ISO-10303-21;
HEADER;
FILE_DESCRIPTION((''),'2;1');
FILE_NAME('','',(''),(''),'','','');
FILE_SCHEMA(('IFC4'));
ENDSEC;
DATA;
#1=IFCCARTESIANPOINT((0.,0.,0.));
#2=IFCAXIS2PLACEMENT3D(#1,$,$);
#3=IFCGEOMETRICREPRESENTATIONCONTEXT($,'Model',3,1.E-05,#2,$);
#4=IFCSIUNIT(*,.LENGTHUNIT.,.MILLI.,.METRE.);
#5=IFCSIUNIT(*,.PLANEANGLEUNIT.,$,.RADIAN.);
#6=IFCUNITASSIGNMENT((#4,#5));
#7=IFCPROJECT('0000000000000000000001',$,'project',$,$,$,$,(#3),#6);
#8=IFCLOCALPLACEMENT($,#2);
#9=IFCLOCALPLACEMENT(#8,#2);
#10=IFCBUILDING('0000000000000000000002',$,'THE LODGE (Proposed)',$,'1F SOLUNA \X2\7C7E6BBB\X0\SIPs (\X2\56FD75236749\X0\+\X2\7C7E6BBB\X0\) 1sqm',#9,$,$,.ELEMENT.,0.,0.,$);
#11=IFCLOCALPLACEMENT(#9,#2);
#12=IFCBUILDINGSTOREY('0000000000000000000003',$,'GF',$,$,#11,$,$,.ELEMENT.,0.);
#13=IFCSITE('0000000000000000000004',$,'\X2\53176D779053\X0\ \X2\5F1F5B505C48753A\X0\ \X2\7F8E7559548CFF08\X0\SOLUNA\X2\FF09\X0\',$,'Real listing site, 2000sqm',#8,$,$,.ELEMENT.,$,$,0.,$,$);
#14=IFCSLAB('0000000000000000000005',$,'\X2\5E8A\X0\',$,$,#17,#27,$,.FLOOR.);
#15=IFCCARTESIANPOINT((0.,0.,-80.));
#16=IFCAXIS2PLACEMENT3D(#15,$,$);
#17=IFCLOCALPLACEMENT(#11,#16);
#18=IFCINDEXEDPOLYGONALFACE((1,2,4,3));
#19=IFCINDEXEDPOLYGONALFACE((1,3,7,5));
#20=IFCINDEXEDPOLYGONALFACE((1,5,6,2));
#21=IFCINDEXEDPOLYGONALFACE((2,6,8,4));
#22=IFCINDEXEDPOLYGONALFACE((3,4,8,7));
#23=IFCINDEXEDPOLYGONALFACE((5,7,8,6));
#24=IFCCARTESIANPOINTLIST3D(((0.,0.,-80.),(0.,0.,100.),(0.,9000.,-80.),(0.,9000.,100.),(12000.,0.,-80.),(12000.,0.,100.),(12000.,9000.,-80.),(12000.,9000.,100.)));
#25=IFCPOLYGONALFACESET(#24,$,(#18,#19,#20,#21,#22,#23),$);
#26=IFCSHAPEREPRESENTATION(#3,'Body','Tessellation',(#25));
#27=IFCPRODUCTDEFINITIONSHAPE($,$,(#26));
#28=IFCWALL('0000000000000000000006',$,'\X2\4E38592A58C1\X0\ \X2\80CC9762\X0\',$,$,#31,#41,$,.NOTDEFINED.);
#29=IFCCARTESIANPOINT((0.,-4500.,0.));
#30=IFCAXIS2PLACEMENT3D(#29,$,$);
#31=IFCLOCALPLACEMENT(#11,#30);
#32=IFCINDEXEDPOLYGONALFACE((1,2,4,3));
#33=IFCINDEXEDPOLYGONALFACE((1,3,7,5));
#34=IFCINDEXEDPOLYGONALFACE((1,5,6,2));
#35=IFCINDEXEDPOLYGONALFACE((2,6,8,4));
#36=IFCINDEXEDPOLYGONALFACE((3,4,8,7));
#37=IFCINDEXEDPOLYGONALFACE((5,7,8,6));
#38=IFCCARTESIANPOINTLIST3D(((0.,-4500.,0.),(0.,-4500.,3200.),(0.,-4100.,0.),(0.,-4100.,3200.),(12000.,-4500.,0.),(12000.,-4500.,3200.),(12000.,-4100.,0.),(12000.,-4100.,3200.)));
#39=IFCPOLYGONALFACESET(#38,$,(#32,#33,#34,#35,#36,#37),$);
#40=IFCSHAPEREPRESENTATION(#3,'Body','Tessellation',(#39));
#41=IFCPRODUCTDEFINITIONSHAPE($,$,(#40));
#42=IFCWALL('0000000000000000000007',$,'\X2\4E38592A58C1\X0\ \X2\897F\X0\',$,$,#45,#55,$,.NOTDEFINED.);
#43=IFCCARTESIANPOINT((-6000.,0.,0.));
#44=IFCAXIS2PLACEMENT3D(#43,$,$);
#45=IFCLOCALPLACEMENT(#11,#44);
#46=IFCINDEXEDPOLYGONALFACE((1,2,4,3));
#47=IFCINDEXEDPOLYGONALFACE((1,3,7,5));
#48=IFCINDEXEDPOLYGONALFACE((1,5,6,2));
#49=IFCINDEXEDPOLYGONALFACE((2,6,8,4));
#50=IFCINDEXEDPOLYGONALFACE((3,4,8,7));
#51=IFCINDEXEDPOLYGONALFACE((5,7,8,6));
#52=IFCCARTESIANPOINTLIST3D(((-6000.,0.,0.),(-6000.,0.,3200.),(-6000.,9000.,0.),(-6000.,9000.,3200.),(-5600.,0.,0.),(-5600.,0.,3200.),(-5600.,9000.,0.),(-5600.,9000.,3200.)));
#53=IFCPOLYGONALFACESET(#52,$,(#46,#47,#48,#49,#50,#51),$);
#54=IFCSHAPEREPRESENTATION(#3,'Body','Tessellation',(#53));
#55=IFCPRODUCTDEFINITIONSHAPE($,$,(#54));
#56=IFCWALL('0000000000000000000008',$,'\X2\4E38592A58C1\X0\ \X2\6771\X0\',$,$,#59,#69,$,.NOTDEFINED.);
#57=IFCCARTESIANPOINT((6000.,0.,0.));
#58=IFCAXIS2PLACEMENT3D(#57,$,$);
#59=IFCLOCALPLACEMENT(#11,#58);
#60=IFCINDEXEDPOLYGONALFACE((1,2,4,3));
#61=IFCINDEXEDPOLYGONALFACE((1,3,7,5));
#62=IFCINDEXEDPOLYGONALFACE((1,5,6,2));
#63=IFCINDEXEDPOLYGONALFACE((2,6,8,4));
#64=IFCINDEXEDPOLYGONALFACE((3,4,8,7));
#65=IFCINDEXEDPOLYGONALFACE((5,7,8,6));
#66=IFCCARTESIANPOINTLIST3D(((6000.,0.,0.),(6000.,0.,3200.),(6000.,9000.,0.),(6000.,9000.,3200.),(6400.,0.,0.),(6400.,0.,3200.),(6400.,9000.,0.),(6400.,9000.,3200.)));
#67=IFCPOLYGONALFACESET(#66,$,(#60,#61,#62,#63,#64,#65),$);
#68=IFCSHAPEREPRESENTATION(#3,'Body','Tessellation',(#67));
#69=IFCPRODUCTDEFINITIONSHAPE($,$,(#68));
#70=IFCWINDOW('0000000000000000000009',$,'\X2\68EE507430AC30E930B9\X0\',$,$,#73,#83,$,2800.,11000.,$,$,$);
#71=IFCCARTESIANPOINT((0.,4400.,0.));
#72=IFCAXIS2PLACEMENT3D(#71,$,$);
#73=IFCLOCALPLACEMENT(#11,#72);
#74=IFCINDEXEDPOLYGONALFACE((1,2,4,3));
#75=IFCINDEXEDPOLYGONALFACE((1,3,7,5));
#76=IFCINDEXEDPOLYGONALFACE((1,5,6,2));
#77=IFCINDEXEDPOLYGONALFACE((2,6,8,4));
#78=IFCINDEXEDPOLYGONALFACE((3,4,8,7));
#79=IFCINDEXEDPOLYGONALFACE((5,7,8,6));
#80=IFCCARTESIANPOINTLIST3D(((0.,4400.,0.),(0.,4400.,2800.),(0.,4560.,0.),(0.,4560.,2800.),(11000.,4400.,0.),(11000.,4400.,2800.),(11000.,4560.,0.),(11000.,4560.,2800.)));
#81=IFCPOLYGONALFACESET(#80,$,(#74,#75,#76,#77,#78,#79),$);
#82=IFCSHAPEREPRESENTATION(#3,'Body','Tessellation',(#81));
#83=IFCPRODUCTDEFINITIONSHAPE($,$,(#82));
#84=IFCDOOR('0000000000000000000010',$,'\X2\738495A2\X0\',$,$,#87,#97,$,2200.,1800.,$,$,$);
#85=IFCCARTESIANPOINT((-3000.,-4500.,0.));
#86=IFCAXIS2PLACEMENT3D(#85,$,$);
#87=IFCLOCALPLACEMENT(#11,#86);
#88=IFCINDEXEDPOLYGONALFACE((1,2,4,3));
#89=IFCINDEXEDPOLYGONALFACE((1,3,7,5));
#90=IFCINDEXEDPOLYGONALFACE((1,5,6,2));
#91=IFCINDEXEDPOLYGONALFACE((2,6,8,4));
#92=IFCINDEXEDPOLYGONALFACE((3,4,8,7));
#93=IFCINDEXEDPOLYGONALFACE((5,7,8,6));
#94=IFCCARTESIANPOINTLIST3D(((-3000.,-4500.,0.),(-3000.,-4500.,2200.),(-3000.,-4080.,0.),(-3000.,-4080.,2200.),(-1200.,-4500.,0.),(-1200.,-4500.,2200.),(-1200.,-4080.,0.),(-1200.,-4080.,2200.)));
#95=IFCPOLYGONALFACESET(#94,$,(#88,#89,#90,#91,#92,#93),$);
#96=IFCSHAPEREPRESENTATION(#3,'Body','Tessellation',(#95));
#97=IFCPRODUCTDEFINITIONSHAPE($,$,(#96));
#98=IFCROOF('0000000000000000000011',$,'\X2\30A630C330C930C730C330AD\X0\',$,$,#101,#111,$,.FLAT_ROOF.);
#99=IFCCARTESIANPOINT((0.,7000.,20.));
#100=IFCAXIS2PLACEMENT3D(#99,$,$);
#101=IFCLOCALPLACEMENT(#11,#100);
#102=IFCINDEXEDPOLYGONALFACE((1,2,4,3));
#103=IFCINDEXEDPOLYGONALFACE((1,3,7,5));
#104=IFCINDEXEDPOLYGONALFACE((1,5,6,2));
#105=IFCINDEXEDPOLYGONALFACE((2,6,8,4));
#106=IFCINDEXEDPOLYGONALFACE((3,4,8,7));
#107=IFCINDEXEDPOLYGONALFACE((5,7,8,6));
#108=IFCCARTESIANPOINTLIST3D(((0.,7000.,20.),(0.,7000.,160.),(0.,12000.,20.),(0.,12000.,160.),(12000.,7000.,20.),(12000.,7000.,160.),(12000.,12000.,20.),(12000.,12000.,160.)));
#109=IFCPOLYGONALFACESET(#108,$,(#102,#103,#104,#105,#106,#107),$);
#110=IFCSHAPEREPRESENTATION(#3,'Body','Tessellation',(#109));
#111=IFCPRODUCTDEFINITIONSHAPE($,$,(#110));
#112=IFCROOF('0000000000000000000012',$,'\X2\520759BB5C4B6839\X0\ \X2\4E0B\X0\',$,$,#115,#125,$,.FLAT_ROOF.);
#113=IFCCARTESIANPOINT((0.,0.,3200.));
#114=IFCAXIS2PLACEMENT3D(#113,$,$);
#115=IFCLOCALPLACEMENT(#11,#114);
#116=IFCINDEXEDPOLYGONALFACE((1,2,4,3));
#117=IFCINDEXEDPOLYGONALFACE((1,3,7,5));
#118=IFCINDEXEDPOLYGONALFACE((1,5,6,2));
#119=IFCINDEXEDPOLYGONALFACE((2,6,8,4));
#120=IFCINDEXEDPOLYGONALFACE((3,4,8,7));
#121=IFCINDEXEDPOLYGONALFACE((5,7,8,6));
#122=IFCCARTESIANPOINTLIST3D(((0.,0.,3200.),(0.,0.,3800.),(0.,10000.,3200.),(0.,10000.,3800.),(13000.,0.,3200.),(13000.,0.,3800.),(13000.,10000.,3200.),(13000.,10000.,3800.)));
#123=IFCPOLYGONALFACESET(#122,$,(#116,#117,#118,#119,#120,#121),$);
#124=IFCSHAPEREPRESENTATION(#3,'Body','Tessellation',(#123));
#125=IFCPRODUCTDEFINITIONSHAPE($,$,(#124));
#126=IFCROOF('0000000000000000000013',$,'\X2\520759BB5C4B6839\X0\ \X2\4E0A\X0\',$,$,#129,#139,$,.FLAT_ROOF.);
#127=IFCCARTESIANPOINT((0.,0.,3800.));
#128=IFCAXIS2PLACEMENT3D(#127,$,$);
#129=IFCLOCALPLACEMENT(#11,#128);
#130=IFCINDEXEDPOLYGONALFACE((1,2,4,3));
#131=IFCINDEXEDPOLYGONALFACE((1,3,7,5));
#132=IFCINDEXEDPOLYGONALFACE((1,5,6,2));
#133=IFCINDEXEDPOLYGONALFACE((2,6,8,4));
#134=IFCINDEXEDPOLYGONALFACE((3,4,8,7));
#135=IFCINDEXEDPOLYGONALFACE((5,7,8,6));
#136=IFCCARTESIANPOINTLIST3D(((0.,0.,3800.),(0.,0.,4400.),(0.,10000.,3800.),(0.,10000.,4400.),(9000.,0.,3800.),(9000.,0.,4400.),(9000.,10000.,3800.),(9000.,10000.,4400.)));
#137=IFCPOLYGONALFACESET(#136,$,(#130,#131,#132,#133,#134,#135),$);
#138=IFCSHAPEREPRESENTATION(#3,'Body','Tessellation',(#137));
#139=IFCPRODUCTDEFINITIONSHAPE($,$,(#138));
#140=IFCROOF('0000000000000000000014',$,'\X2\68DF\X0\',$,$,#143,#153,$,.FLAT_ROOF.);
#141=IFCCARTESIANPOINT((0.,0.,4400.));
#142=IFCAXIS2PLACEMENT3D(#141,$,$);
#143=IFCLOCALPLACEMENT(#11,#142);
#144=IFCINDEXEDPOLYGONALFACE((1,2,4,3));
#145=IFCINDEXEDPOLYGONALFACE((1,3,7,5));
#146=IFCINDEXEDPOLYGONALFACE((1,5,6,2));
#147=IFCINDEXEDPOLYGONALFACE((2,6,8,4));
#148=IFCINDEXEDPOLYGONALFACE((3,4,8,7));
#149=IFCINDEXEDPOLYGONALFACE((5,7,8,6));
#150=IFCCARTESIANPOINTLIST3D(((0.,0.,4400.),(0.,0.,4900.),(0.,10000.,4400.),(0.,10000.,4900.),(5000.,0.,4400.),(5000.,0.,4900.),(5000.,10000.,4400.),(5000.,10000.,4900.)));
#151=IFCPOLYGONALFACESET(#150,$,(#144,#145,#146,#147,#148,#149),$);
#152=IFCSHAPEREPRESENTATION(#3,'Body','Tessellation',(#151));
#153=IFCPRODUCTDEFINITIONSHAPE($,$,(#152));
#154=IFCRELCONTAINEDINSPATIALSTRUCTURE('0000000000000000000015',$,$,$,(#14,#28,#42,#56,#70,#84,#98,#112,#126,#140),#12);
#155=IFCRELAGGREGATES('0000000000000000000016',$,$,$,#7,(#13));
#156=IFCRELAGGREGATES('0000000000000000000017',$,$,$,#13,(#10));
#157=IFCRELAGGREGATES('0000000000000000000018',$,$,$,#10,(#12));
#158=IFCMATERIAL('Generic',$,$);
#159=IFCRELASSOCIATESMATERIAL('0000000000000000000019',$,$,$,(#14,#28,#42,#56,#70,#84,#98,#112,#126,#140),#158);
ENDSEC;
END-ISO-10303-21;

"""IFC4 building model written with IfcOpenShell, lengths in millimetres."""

from ifc_helpers import new_model, si_unit, frame, frame_2d, origin, place, context, project, spatial, rectangle, extrude, material, element, fill, save


model = new_model("IFC4")

# Units and contexts
model_context = context("Model", 3, precision=1e-05, world=origin())
ifc_project = project(units=[si_unit("LENGTHUNIT", "METRE", prefix="MILLI"), si_unit("PLANEANGLEUNIT", "RADIAN")], contexts=[model_context])

# Site, building, storey
site_placement = place(None, origin())
site = spatial("IfcSite", under=ifc_project, at=site_placement, Name="北海道 弟子屈町 美留和（SOLUNA）", ObjectType="Real listing site, 2000sqm", CompositionType="ELEMENT", RefElevation=0.0)
building_placement = place(site_placement, origin())
building = spatial("IfcBuilding", under=site, at=building_placement, Name="THE LODGE (Proposed)", ObjectType="1F SOLUNA 籾殻SIPs (国産杉+籾殻) 1sqm", CompositionType="ELEMENT", ElevationOfRefHeight=0.0, ElevationOfTerrain=0.0)
storey_placement = place(building_placement, origin())
storey = spatial("IfcBuildingStorey", under=building, at=storey_placement, Name="GF", CompositionType="ELEMENT", Elevation=0.0)

# Slab
ifc_material_1 = material(Name="Generic")
slab_placement = place(storey_placement, frame((0.0, 0.0, -80.0)))
element("IfcSlab", 1, at=slab_placement, inside=storey, material=ifc_material_1, Name="床", PredefinedType="FLOOR", context=model_context, shape_type="SweptSolid", body=[
    extrude(rectangle(XDim=12000.0, YDim=9000.0, at=frame_2d((6000.0, 4500.0))), frame((0.0, 0.0, -80.0)), (0.0, 0.0, 1.0), 180.0),
])

# Walls
wall_1_placement = place(storey_placement, frame((0.0, -4500.0, 0.0)))
element("IfcWall", 2, at=wall_1_placement, inside=storey, material=ifc_material_1, Name="丸太壁 背面", PredefinedType="NOTDEFINED", context=model_context, shape_type="SweptSolid", body=[
    extrude(rectangle(XDim=12000.0, YDim=400.0, at=frame_2d((6000.0, 200.0))), frame((0.0, -4500.0, 0.0)), (0.0, 0.0, 1.0), 3200.0),
])
wall_2_placement = place(storey_placement, frame((-6000.0, 0.0, 0.0)))
element("IfcWall", 3, at=wall_2_placement, inside=storey, material=ifc_material_1, Name="丸太壁 西", PredefinedType="NOTDEFINED", context=model_context, shape_type="SweptSolid", body=[
    extrude(rectangle(XDim=400.0, YDim=9000.0, at=frame_2d((200.0, 4500.0))), frame((-6000.0, 0.0, 0.0)), (0.0, 0.0, 1.0), 3200.0),
])

# Wall, opening, window
wall_3_placement = place(storey_placement, frame((6000.0, 0.0, 0.0)))
wall_3 = element("IfcWall", 4, at=wall_3_placement, inside=storey, material=ifc_material_1, Name="丸太壁 東", PredefinedType="NOTDEFINED", context=model_context, shape_type="SweptSolid", body=[
    extrude(rectangle(XDim=400.0, YDim=9000.0, at=frame_2d((200.0, 4500.0))), frame((6000.0, 0.0, 0.0)), (0.0, 0.0, 1.0), 3200.0),
])
opening_placement = place(storey_placement, frame((0.0, 4400.0, 0.0)))
opening = element("IfcOpeningElement", 5, at=opening_placement, cuts=wall_3, PredefinedType="NOTDEFINED", context=model_context, shape_type="SweptSolid", body=[
    extrude(rectangle(XDim=11000.0, YDim=160.0, at=frame_2d((5500.0, 80.0))), frame((0.0, 4400.0, 0.0)), (0.0, 0.0, 1.0), 2800.0),
])
window_placement = place(storey_placement, frame((0.0, 4400.0, 0.0)))
window = element("IfcWindow", 6, at=window_placement, inside=storey, material=ifc_material_1, Name="森側ガラス", OverallHeight=2800.0, OverallWidth=11000.0, context=model_context, shape_type="SweptSolid", body=[
    extrude(rectangle(XDim=11000.0, YDim=160.0, at=frame_2d((5500.0, 80.0))), frame((0.0, 4400.0, 0.0)), (0.0, 0.0, 1.0), 2800.0),
])
fill(opening, window)

# Door
door_placement = place(storey_placement, frame((-3000.0, -4500.0, 0.0)))
element("IfcDoor", 7, at=door_placement, inside=storey, material=ifc_material_1, Name="玄関", OverallHeight=2200.0, OverallWidth=1800.0, context=model_context, shape_type="SweptSolid", body=[
    extrude(rectangle(XDim=1800.0, YDim=420.0, at=frame_2d((900.0, 210.0))), frame((-3000.0, -4500.0, 0.0)), (0.0, 0.0, 1.0), 2200.0),
])

# Roofs
roof_1_placement = place(storey_placement, frame((0.0, 7000.0, 20.0)))
element("IfcRoof", 8, at=roof_1_placement, inside=storey, material=ifc_material_1, Name="ウッドデッキ", PredefinedType="FLAT_ROOF", context=model_context, shape_type="SweptSolid", body=[
    extrude(rectangle(XDim=12000.0, YDim=5000.0, at=frame_2d((6000.0, 2500.0))), frame((0.0, 7000.0, 20.0)), (0.0, 0.0, 1.0), 140.0),
])
roof_2_placement = place(storey_placement, frame((0.0, 0.0, 3200.0)))
element("IfcRoof", 9, at=roof_2_placement, inside=storey, material=ifc_material_1, Name="切妻屋根 下", PredefinedType="FLAT_ROOF", context=model_context, shape_type="SweptSolid", body=[
    extrude(rectangle(XDim=13000.0, YDim=10000.0, at=frame_2d((6500.0, 5000.0))), frame((0.0, 0.0, 3200.0)), (0.0, 0.0, 1.0), 600.0),
])
roof_3_placement = place(storey_placement, frame((0.0, 0.0, 3800.0)))
element("IfcRoof", 10, at=roof_3_placement, inside=storey, material=ifc_material_1, Name="切妻屋根 上", PredefinedType="FLAT_ROOF", context=model_context, shape_type="SweptSolid", body=[
    extrude(rectangle(XDim=9000.0, YDim=10000.0, at=frame_2d((4500.0, 5000.0))), frame((0.0, 0.0, 3800.0)), (0.0, 0.0, 1.0), 600.0),
])
roof_4_placement = place(storey_placement, frame((0.0, 0.0, 4400.0)))
element("IfcRoof", 11, at=roof_4_placement, inside=storey, material=ifc_material_1, Name="棟", PredefinedType="FLAT_ROOF", context=model_context, shape_type="SweptSolid", body=[
    extrude(rectangle(XDim=5000.0, YDim=10000.0, at=frame_2d((2500.0, 5000.0))), frame((0.0, 0.0, 4400.0)), (0.0, 0.0, 1.0), 500.0),
])

save(model, "model.ifc")
